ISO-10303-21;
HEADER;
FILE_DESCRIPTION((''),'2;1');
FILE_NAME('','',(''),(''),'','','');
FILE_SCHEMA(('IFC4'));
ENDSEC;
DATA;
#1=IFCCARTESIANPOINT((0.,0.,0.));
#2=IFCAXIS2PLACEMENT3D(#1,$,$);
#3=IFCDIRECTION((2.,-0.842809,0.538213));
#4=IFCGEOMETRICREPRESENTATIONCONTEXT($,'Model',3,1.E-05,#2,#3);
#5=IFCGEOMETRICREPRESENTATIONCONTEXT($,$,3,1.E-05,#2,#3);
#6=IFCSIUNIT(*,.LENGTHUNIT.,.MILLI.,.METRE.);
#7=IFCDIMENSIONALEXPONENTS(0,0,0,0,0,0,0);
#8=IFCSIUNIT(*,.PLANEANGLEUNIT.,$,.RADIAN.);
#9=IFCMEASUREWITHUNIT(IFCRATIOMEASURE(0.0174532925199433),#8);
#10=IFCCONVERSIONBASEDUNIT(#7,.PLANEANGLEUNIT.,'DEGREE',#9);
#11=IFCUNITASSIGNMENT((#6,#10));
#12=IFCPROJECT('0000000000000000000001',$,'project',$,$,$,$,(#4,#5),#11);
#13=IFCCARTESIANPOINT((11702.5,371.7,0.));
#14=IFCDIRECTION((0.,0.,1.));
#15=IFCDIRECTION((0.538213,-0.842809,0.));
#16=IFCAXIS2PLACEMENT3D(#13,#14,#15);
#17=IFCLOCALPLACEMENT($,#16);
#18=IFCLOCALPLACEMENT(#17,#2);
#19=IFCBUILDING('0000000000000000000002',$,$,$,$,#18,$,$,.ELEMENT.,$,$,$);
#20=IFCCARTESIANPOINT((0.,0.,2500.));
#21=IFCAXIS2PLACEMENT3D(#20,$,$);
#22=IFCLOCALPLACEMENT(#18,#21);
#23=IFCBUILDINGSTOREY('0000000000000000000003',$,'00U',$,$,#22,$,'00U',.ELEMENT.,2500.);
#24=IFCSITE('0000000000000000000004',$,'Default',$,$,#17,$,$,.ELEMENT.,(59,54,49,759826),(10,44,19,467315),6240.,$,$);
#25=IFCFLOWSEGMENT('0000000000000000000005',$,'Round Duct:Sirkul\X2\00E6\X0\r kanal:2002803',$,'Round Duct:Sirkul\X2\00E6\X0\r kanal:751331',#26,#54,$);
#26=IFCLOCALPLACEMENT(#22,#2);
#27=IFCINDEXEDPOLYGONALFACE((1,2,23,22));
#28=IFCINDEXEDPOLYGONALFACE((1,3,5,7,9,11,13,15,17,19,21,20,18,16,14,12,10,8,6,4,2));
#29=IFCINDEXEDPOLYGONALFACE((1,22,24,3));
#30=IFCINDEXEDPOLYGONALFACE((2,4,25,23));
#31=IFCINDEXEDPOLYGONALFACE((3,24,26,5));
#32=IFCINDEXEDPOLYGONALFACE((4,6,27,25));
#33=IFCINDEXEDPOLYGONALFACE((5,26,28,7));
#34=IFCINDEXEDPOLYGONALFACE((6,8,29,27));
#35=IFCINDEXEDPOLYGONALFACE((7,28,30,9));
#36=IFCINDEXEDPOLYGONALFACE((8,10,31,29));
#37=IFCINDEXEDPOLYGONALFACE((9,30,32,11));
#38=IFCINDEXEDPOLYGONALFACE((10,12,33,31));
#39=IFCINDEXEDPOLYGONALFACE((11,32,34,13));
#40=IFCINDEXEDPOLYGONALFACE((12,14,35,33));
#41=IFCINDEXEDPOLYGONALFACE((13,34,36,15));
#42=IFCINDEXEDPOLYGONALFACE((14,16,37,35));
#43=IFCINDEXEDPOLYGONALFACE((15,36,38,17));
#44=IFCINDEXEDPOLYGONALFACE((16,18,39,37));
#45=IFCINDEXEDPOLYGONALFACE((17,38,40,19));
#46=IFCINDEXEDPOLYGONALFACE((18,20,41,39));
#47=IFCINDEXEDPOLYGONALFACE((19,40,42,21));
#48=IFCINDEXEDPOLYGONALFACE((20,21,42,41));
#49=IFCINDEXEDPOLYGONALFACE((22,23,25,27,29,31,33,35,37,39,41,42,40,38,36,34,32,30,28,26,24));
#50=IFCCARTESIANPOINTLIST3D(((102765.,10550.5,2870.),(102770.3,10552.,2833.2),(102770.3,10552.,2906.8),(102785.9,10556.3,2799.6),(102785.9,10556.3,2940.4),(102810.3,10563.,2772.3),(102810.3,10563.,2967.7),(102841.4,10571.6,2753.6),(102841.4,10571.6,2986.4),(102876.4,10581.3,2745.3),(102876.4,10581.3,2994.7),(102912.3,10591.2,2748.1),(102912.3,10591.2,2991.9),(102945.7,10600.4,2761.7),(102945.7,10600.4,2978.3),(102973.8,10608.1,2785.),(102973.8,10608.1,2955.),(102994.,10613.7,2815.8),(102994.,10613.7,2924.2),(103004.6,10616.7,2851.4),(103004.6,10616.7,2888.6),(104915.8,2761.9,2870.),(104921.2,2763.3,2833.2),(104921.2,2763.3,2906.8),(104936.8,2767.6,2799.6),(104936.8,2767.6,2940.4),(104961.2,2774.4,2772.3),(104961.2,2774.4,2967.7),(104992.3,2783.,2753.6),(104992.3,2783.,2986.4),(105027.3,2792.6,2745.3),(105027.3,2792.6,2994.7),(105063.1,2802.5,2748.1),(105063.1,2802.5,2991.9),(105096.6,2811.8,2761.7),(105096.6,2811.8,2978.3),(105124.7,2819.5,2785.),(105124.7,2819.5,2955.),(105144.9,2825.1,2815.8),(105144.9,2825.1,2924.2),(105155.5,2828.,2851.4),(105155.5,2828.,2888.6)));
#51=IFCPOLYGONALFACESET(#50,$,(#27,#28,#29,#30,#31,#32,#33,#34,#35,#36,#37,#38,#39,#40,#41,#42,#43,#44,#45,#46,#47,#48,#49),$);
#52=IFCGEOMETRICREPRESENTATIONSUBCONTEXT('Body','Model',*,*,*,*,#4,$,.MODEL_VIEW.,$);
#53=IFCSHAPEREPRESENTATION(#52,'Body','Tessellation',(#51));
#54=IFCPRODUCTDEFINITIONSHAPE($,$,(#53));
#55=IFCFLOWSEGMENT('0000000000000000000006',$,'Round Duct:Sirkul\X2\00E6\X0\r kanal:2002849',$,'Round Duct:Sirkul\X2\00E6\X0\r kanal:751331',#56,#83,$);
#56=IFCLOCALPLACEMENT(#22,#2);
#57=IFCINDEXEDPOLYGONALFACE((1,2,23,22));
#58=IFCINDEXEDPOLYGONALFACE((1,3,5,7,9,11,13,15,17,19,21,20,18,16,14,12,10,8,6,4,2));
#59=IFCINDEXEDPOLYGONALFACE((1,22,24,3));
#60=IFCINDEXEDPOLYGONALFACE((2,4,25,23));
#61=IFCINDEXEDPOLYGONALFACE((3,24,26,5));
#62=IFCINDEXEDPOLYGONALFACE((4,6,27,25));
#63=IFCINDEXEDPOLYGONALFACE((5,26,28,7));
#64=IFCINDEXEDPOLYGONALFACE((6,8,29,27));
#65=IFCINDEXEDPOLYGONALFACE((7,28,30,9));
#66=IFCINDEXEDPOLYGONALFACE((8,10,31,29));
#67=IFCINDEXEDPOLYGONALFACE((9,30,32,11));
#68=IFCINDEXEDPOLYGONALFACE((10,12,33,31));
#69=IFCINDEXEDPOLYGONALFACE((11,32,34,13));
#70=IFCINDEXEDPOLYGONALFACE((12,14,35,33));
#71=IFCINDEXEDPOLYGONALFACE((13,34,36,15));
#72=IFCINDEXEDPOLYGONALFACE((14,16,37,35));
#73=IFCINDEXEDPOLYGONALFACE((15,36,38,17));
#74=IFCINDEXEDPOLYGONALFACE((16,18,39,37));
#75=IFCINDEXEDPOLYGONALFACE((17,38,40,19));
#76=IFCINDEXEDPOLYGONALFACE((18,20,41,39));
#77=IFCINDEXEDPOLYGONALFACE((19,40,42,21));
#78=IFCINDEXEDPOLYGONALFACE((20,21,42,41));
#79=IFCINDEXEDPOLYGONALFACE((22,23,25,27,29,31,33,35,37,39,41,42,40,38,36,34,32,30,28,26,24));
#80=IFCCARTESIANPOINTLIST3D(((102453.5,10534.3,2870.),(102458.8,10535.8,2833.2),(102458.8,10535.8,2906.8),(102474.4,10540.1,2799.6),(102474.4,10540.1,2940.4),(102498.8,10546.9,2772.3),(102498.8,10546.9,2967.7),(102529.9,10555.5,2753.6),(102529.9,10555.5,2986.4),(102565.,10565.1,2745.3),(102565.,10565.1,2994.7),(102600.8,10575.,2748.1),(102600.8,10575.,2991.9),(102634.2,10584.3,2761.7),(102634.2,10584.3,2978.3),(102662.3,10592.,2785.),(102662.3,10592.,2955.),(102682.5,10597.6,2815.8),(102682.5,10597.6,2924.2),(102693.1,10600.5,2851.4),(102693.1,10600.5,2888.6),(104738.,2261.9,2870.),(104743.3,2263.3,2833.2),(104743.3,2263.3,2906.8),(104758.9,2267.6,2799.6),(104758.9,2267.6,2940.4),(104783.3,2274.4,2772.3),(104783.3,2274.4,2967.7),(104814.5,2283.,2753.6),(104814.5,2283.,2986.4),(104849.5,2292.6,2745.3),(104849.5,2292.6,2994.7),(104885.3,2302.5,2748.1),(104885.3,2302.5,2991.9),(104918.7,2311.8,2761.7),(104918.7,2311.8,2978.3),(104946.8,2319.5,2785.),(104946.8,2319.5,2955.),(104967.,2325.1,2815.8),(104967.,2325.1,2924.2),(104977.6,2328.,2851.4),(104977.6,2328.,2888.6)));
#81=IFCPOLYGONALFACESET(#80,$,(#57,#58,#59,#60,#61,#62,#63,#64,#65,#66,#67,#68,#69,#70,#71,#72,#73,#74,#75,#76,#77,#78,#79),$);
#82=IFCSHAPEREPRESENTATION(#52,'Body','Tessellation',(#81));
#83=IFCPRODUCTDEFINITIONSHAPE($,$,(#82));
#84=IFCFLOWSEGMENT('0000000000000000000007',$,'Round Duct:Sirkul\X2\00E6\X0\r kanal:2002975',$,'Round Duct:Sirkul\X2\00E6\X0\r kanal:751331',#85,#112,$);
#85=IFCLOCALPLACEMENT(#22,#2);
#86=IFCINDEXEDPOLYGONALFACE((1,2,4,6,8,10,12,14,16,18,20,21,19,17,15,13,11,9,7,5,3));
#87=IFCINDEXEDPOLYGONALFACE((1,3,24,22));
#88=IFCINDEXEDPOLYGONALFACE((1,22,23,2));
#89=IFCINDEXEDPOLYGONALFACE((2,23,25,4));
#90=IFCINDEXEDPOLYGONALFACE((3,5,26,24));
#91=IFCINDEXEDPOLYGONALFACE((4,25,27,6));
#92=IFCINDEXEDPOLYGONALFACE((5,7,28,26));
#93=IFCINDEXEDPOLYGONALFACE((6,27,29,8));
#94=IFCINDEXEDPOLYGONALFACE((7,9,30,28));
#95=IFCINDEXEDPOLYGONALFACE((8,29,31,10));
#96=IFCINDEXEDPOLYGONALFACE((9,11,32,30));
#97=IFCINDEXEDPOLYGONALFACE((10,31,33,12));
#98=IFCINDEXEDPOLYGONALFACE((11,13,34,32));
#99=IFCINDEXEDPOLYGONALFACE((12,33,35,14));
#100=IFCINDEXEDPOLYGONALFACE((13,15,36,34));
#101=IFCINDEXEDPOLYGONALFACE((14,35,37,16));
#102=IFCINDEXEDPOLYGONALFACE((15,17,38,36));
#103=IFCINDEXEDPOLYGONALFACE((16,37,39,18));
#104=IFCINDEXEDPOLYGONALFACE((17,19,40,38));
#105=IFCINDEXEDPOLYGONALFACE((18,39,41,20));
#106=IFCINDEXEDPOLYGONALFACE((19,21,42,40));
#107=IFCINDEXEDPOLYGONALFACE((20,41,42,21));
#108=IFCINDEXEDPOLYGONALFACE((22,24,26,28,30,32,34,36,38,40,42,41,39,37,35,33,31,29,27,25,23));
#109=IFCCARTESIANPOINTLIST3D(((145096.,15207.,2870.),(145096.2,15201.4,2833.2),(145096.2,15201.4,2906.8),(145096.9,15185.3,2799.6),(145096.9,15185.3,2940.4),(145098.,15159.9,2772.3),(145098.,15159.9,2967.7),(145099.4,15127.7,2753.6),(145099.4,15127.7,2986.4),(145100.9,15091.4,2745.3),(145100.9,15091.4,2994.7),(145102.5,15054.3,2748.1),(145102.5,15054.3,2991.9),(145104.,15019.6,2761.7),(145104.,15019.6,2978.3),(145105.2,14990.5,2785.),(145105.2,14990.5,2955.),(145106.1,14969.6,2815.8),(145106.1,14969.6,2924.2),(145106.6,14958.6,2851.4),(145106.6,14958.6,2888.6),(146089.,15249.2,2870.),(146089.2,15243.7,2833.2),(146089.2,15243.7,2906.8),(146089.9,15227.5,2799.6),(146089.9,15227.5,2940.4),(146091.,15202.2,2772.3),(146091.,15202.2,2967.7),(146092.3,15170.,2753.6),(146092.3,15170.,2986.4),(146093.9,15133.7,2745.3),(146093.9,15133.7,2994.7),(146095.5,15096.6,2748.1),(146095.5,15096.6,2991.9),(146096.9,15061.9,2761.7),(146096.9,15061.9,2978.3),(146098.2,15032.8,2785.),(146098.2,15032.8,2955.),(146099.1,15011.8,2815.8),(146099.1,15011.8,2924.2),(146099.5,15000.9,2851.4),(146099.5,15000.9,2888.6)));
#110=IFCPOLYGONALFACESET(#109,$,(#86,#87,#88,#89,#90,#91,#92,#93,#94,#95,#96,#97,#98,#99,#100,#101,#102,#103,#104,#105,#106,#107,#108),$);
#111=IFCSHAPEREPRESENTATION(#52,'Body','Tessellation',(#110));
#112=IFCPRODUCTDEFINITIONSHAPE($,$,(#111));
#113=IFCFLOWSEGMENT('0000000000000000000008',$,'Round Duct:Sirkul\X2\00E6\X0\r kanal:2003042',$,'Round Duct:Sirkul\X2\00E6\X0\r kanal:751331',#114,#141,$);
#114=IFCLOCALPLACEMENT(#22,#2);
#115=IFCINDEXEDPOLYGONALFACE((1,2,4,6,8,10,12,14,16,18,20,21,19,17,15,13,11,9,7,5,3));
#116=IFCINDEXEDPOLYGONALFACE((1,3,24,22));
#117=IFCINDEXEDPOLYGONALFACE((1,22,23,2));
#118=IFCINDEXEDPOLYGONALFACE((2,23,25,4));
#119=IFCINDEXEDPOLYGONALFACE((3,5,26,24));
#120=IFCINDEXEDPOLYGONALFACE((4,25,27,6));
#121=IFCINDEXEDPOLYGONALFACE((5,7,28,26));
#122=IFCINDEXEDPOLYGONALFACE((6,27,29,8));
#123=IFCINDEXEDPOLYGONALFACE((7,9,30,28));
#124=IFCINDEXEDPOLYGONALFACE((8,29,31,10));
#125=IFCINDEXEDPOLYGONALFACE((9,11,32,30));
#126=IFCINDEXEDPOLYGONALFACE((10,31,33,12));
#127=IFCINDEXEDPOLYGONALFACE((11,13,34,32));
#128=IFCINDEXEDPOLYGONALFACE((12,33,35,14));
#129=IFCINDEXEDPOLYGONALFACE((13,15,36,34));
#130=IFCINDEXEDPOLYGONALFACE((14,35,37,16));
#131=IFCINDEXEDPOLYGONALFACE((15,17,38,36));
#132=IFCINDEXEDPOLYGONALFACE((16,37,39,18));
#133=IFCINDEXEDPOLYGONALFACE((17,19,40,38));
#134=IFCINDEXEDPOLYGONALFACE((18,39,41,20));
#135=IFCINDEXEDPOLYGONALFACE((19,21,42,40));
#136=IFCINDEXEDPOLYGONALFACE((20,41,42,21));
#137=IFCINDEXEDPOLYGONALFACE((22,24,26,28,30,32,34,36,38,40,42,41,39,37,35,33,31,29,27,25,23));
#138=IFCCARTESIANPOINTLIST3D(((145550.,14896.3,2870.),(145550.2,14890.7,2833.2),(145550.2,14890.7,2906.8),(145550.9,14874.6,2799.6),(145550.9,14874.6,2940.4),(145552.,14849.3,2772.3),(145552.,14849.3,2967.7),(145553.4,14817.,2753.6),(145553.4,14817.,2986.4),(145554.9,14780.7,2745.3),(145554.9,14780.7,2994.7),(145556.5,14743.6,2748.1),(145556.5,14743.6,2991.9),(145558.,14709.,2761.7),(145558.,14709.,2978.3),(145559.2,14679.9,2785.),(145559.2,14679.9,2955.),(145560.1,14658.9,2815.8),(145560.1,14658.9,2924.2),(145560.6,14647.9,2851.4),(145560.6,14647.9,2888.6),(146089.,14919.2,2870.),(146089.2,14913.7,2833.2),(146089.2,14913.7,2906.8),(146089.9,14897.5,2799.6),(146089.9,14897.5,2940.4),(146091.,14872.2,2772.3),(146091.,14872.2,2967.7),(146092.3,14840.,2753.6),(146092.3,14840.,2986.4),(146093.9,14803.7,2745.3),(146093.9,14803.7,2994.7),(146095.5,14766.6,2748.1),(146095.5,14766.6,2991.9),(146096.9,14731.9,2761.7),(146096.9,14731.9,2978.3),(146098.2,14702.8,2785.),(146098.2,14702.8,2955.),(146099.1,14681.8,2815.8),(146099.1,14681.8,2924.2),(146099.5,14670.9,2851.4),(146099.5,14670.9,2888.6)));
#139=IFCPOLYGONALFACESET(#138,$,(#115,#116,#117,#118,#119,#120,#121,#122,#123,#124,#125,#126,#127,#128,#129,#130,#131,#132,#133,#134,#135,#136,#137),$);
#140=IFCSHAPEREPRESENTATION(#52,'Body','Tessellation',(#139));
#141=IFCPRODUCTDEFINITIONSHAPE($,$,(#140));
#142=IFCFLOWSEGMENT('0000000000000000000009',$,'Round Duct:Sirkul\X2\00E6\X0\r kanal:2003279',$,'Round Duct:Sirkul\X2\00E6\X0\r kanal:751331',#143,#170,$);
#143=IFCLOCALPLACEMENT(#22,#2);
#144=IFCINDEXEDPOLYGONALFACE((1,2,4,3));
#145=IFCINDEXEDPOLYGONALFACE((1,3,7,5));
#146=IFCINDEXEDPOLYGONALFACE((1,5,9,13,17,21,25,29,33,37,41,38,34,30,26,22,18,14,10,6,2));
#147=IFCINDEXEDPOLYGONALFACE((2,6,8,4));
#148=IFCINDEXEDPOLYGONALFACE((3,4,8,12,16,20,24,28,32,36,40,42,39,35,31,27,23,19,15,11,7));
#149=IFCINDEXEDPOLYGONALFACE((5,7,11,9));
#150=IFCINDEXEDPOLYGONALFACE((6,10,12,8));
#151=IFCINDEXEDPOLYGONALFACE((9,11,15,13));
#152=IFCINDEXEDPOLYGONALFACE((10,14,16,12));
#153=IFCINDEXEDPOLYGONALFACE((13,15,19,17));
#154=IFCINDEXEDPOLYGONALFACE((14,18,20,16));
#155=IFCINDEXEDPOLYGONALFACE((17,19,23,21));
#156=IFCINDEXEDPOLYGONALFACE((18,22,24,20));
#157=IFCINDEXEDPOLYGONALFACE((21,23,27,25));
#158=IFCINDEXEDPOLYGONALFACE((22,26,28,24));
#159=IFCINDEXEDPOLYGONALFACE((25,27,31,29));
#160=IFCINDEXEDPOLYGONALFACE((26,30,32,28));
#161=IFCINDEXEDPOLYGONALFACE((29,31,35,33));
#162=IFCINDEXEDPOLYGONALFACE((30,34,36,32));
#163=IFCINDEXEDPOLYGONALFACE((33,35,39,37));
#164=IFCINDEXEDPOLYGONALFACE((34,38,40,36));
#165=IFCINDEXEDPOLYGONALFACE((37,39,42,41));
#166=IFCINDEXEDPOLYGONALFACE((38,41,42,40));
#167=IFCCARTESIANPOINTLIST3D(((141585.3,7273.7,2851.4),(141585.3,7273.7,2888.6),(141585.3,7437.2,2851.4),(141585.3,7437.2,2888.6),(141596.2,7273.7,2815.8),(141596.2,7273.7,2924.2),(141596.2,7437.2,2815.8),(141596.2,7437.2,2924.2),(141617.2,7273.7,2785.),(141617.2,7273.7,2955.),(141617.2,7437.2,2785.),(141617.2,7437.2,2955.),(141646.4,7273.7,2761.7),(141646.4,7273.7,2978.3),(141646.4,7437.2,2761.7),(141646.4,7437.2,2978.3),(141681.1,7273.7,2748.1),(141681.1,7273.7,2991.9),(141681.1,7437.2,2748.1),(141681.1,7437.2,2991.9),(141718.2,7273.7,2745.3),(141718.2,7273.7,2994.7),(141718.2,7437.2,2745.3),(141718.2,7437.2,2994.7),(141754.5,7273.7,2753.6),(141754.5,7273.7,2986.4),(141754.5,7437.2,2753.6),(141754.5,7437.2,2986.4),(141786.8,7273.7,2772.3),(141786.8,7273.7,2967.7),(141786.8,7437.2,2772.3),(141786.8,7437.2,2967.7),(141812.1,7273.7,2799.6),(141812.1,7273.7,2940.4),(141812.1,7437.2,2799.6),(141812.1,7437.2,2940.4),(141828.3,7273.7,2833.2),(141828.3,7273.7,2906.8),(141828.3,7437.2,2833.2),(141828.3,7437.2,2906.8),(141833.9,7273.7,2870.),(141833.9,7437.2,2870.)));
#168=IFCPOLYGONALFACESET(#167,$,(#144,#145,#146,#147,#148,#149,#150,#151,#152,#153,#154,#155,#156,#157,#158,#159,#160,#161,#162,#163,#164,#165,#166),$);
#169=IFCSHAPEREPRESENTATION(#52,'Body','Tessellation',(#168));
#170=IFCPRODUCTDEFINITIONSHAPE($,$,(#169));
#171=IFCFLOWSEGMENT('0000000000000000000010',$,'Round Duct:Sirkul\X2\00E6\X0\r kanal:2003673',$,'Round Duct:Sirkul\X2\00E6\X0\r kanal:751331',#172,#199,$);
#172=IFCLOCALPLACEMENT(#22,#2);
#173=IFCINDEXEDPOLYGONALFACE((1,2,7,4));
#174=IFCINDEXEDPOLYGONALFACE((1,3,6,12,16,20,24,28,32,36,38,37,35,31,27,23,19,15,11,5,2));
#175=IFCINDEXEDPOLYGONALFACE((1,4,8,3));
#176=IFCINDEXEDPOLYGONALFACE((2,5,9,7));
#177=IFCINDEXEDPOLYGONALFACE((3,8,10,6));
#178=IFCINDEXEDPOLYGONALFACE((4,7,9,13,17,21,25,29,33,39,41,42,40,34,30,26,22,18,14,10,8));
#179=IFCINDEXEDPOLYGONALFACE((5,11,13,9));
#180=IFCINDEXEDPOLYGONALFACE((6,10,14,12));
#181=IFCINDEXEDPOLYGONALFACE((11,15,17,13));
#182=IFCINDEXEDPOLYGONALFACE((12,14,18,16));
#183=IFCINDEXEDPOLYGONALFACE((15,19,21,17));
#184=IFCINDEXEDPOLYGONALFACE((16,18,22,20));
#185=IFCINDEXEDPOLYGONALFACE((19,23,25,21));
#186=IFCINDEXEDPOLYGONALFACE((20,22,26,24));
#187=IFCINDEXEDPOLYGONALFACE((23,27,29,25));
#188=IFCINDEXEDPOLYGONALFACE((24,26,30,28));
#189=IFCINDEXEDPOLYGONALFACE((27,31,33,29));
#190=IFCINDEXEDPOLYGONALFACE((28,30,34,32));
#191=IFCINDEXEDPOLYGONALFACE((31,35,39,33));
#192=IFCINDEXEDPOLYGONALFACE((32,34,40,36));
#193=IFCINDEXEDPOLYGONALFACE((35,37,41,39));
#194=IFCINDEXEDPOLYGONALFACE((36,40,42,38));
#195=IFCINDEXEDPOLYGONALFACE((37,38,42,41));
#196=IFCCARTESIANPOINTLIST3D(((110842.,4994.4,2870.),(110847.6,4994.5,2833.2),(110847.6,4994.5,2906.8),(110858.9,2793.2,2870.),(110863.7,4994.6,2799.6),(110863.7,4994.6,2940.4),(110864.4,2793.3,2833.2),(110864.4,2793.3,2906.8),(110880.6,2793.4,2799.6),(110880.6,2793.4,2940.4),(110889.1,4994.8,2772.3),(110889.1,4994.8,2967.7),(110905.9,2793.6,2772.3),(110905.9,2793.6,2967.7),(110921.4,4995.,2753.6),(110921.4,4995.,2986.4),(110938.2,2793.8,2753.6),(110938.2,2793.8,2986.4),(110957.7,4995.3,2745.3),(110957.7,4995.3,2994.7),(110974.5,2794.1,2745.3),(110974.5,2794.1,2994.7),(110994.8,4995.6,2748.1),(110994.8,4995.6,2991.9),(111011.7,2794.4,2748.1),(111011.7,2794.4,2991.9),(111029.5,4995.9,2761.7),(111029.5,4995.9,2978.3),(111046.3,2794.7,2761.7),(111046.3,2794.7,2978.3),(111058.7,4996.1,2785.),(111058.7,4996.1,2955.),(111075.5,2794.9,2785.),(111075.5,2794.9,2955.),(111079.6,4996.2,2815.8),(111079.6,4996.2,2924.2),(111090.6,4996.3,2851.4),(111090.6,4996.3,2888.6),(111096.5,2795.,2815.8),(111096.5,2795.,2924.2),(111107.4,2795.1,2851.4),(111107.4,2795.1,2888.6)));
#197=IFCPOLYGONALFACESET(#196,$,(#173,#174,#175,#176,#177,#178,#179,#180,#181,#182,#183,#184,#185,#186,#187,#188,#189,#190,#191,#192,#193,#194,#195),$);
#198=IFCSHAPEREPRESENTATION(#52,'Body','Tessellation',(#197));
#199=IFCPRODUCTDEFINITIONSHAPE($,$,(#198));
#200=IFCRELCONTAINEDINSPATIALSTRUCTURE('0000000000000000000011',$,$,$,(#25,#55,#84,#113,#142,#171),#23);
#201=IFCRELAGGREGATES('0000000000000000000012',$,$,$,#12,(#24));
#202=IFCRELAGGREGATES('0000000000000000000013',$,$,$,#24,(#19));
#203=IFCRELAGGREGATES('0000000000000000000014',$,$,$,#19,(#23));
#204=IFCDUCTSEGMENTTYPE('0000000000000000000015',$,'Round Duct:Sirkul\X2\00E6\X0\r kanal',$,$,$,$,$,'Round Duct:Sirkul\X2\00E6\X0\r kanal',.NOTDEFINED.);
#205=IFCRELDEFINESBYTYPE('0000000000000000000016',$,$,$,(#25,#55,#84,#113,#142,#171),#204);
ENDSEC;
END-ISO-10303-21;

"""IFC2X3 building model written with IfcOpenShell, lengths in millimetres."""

from ifc_helpers import new_model, entity, si_unit, converted_unit, direction, frame, frame_2d, origin, origin_2d_with_axis, place, context, subcontext, project, spatial, circle, extrude, type_object, element, save


model = new_model("IFC2X3")

# Units and contexts
model_context = context("Model", 3, precision=1e-05, world=origin(), true_north=direction((2.0, -0.842809, 0.538213)))
context_of_model = context(None, 3, precision=1e-05, world=origin(), true_north=direction((2.0, -0.842809, 0.538213)))
body_context = subcontext(model_context, "Body", "Model", "MODEL_VIEW")
ifc_project = project(units=[si_unit("LENGTHUNIT", "METRE", prefix="MILLI"), converted_unit("PLANEANGLEUNIT", "DEGREE", entity("IfcRatioMeasure", 0.0174532925199433), si_unit("PLANEANGLEUNIT", "RADIAN"), dimensions=[0, 0, 0, 0, 0, 0, 0])], contexts=[model_context, context_of_model])

# Site, building, storey
site_placement = place(None, frame((11702.5, 371.7, 0.0), z_axis=(0.0, 0.0, 1.0), x_axis=(0.538213, -0.842809, 0.0)))
site = spatial("IfcSite", under=ifc_project, at=site_placement, Name="Default", CompositionType="ELEMENT", RefLatitude=(59, 54, 49, 759826), RefLongitude=(10, 44, 19, 467315), RefElevation=6240.0)
building_placement = place(site_placement, origin())
building = spatial("IfcBuilding", under=site, at=building_placement, CompositionType="ELEMENT")
storey_placement = place(building_placement, frame((0.0, 0.0, 2500.0)))
storey = spatial("IfcBuildingStorey", under=building, at=storey_placement, Name="00U", LongName="00U", CompositionType="ELEMENT", Elevation=2500.0)

# Flow segments
duct_segment_type_1 = type_object("IfcDuctSegmentType", Name="Round Duct:Sirkulær kanal", ElementType="Round Duct:Sirkulær kanal", PredefinedType="NOTDEFINED")
flow_segment_1_placement = place(storey_placement, origin())
element("IfcFlowSegment", 1, at=flow_segment_1_placement, inside=storey, type_object=duct_segment_type_1, Name="Round Duct:Sirkulær kanal:2002803", ObjectType="Round Duct:Sirkulær kanal:751331", context=body_context, shape_type="SweptSolid", body=[
    extrude(circle(Radius=125.0, at=origin_2d_with_axis()), frame((102885.4, 10583.8, 2870.0), z_axis=(0.266194, -0.96392, 0.0), x_axis=(-0.96392, -0.266194, 0.0)), (0.0, 0.0, 1.0), 8080.2),
])
flow_segment_2_placement = place(storey_placement, origin())
element("IfcFlowSegment", 2, at=flow_segment_2_placement, inside=storey, type_object=duct_segment_type_1, Name="Round Duct:Sirkulær kanal:2002849", ObjectType="Round Duct:Sirkulær kanal:751331", context=body_context, shape_type="SweptSolid", body=[
    extrude(circle(Radius=125.0, at=origin_2d_with_axis()), frame((102574.0, 10567.6, 2870.0), z_axis=(0.266194, -0.96392, 0.0), x_axis=(-0.96392, -0.266194, 0.0)), (0.0, 0.0, 1.0), 8582.1),
])
flow_segment_3_placement = place(storey_placement, origin())
element("IfcFlowSegment", 3, at=flow_segment_3_placement, inside=storey, type_object=duct_segment_type_1, Name="Round Duct:Sirkulær kanal:2002975", ObjectType="Round Duct:Sirkulær kanal:751331", context=body_context, shape_type="SweptSolid", body=[
    extrude(circle(Radius=125.0, at=origin_2d_with_axis()), frame((145101.3, 15082.1, 2870.0), z_axis=(0.999095, 0.042537, 0.0), x_axis=(-0.042537, 0.999095, 0.0)), (0.0, 0.0, 1.0), 993.8),
])
flow_segment_4_placement = place(storey_placement, origin())
element("IfcFlowSegment", 4, at=flow_segment_4_placement, inside=storey, type_object=duct_segment_type_1, Name="Round Duct:Sirkulær kanal:2003042", ObjectType="Round Duct:Sirkulær kanal:751331", context=body_context, shape_type="SweptSolid", body=[
    extrude(circle(Radius=125.0, at=origin_2d_with_axis()), frame((145555.3, 14771.4, 2870.0), z_axis=(0.999095, 0.042537, 0.0), x_axis=(-0.042537, 0.999095, 0.0)), (0.0, 0.0, 1.0), 539.4),
])
flow_segment_5_placement = place(storey_placement, origin())
element("IfcFlowSegment", 5, at=flow_segment_5_placement, inside=storey, type_object=duct_segment_type_1, Name="Round Duct:Sirkulær kanal:2003279", ObjectType="Round Duct:Sirkulær kanal:751331", context=body_context, shape_type="SweptSolid", body=[
    extrude(circle(Radius=125.0, at=origin_2d_with_axis()), frame((141708.9, 7273.7, 2870.0), z_axis=(0.0, 1.0, 0.0), x_axis=(1.0, 0.0, 0.0)), (0.0, 0.0, 1.0), 163.5),
])
flow_segment_6_placement = place(storey_placement, origin())
element("IfcFlowSegment", 6, at=flow_segment_6_placement, inside=storey, type_object=duct_segment_type_1, Name="Round Duct:Sirkulær kanal:2003673", ObjectType="Round Duct:Sirkulær kanal:751331", context=body_context, shape_type="SweptSolid", body=[
    extrude(circle(Radius=125.0, at=frame_2d((0.0, 0.0), x_axis=(1.0, 0.0))), frame((110983.8, 2794.2, 2870.0), z_axis=(-0.007643, 0.999971, 0.0), x_axis=(-0.999971, -0.007643, 0.0)), (0.0, 0.0, 1.0), 2201.3),
])

save(model, "model.ifc")
